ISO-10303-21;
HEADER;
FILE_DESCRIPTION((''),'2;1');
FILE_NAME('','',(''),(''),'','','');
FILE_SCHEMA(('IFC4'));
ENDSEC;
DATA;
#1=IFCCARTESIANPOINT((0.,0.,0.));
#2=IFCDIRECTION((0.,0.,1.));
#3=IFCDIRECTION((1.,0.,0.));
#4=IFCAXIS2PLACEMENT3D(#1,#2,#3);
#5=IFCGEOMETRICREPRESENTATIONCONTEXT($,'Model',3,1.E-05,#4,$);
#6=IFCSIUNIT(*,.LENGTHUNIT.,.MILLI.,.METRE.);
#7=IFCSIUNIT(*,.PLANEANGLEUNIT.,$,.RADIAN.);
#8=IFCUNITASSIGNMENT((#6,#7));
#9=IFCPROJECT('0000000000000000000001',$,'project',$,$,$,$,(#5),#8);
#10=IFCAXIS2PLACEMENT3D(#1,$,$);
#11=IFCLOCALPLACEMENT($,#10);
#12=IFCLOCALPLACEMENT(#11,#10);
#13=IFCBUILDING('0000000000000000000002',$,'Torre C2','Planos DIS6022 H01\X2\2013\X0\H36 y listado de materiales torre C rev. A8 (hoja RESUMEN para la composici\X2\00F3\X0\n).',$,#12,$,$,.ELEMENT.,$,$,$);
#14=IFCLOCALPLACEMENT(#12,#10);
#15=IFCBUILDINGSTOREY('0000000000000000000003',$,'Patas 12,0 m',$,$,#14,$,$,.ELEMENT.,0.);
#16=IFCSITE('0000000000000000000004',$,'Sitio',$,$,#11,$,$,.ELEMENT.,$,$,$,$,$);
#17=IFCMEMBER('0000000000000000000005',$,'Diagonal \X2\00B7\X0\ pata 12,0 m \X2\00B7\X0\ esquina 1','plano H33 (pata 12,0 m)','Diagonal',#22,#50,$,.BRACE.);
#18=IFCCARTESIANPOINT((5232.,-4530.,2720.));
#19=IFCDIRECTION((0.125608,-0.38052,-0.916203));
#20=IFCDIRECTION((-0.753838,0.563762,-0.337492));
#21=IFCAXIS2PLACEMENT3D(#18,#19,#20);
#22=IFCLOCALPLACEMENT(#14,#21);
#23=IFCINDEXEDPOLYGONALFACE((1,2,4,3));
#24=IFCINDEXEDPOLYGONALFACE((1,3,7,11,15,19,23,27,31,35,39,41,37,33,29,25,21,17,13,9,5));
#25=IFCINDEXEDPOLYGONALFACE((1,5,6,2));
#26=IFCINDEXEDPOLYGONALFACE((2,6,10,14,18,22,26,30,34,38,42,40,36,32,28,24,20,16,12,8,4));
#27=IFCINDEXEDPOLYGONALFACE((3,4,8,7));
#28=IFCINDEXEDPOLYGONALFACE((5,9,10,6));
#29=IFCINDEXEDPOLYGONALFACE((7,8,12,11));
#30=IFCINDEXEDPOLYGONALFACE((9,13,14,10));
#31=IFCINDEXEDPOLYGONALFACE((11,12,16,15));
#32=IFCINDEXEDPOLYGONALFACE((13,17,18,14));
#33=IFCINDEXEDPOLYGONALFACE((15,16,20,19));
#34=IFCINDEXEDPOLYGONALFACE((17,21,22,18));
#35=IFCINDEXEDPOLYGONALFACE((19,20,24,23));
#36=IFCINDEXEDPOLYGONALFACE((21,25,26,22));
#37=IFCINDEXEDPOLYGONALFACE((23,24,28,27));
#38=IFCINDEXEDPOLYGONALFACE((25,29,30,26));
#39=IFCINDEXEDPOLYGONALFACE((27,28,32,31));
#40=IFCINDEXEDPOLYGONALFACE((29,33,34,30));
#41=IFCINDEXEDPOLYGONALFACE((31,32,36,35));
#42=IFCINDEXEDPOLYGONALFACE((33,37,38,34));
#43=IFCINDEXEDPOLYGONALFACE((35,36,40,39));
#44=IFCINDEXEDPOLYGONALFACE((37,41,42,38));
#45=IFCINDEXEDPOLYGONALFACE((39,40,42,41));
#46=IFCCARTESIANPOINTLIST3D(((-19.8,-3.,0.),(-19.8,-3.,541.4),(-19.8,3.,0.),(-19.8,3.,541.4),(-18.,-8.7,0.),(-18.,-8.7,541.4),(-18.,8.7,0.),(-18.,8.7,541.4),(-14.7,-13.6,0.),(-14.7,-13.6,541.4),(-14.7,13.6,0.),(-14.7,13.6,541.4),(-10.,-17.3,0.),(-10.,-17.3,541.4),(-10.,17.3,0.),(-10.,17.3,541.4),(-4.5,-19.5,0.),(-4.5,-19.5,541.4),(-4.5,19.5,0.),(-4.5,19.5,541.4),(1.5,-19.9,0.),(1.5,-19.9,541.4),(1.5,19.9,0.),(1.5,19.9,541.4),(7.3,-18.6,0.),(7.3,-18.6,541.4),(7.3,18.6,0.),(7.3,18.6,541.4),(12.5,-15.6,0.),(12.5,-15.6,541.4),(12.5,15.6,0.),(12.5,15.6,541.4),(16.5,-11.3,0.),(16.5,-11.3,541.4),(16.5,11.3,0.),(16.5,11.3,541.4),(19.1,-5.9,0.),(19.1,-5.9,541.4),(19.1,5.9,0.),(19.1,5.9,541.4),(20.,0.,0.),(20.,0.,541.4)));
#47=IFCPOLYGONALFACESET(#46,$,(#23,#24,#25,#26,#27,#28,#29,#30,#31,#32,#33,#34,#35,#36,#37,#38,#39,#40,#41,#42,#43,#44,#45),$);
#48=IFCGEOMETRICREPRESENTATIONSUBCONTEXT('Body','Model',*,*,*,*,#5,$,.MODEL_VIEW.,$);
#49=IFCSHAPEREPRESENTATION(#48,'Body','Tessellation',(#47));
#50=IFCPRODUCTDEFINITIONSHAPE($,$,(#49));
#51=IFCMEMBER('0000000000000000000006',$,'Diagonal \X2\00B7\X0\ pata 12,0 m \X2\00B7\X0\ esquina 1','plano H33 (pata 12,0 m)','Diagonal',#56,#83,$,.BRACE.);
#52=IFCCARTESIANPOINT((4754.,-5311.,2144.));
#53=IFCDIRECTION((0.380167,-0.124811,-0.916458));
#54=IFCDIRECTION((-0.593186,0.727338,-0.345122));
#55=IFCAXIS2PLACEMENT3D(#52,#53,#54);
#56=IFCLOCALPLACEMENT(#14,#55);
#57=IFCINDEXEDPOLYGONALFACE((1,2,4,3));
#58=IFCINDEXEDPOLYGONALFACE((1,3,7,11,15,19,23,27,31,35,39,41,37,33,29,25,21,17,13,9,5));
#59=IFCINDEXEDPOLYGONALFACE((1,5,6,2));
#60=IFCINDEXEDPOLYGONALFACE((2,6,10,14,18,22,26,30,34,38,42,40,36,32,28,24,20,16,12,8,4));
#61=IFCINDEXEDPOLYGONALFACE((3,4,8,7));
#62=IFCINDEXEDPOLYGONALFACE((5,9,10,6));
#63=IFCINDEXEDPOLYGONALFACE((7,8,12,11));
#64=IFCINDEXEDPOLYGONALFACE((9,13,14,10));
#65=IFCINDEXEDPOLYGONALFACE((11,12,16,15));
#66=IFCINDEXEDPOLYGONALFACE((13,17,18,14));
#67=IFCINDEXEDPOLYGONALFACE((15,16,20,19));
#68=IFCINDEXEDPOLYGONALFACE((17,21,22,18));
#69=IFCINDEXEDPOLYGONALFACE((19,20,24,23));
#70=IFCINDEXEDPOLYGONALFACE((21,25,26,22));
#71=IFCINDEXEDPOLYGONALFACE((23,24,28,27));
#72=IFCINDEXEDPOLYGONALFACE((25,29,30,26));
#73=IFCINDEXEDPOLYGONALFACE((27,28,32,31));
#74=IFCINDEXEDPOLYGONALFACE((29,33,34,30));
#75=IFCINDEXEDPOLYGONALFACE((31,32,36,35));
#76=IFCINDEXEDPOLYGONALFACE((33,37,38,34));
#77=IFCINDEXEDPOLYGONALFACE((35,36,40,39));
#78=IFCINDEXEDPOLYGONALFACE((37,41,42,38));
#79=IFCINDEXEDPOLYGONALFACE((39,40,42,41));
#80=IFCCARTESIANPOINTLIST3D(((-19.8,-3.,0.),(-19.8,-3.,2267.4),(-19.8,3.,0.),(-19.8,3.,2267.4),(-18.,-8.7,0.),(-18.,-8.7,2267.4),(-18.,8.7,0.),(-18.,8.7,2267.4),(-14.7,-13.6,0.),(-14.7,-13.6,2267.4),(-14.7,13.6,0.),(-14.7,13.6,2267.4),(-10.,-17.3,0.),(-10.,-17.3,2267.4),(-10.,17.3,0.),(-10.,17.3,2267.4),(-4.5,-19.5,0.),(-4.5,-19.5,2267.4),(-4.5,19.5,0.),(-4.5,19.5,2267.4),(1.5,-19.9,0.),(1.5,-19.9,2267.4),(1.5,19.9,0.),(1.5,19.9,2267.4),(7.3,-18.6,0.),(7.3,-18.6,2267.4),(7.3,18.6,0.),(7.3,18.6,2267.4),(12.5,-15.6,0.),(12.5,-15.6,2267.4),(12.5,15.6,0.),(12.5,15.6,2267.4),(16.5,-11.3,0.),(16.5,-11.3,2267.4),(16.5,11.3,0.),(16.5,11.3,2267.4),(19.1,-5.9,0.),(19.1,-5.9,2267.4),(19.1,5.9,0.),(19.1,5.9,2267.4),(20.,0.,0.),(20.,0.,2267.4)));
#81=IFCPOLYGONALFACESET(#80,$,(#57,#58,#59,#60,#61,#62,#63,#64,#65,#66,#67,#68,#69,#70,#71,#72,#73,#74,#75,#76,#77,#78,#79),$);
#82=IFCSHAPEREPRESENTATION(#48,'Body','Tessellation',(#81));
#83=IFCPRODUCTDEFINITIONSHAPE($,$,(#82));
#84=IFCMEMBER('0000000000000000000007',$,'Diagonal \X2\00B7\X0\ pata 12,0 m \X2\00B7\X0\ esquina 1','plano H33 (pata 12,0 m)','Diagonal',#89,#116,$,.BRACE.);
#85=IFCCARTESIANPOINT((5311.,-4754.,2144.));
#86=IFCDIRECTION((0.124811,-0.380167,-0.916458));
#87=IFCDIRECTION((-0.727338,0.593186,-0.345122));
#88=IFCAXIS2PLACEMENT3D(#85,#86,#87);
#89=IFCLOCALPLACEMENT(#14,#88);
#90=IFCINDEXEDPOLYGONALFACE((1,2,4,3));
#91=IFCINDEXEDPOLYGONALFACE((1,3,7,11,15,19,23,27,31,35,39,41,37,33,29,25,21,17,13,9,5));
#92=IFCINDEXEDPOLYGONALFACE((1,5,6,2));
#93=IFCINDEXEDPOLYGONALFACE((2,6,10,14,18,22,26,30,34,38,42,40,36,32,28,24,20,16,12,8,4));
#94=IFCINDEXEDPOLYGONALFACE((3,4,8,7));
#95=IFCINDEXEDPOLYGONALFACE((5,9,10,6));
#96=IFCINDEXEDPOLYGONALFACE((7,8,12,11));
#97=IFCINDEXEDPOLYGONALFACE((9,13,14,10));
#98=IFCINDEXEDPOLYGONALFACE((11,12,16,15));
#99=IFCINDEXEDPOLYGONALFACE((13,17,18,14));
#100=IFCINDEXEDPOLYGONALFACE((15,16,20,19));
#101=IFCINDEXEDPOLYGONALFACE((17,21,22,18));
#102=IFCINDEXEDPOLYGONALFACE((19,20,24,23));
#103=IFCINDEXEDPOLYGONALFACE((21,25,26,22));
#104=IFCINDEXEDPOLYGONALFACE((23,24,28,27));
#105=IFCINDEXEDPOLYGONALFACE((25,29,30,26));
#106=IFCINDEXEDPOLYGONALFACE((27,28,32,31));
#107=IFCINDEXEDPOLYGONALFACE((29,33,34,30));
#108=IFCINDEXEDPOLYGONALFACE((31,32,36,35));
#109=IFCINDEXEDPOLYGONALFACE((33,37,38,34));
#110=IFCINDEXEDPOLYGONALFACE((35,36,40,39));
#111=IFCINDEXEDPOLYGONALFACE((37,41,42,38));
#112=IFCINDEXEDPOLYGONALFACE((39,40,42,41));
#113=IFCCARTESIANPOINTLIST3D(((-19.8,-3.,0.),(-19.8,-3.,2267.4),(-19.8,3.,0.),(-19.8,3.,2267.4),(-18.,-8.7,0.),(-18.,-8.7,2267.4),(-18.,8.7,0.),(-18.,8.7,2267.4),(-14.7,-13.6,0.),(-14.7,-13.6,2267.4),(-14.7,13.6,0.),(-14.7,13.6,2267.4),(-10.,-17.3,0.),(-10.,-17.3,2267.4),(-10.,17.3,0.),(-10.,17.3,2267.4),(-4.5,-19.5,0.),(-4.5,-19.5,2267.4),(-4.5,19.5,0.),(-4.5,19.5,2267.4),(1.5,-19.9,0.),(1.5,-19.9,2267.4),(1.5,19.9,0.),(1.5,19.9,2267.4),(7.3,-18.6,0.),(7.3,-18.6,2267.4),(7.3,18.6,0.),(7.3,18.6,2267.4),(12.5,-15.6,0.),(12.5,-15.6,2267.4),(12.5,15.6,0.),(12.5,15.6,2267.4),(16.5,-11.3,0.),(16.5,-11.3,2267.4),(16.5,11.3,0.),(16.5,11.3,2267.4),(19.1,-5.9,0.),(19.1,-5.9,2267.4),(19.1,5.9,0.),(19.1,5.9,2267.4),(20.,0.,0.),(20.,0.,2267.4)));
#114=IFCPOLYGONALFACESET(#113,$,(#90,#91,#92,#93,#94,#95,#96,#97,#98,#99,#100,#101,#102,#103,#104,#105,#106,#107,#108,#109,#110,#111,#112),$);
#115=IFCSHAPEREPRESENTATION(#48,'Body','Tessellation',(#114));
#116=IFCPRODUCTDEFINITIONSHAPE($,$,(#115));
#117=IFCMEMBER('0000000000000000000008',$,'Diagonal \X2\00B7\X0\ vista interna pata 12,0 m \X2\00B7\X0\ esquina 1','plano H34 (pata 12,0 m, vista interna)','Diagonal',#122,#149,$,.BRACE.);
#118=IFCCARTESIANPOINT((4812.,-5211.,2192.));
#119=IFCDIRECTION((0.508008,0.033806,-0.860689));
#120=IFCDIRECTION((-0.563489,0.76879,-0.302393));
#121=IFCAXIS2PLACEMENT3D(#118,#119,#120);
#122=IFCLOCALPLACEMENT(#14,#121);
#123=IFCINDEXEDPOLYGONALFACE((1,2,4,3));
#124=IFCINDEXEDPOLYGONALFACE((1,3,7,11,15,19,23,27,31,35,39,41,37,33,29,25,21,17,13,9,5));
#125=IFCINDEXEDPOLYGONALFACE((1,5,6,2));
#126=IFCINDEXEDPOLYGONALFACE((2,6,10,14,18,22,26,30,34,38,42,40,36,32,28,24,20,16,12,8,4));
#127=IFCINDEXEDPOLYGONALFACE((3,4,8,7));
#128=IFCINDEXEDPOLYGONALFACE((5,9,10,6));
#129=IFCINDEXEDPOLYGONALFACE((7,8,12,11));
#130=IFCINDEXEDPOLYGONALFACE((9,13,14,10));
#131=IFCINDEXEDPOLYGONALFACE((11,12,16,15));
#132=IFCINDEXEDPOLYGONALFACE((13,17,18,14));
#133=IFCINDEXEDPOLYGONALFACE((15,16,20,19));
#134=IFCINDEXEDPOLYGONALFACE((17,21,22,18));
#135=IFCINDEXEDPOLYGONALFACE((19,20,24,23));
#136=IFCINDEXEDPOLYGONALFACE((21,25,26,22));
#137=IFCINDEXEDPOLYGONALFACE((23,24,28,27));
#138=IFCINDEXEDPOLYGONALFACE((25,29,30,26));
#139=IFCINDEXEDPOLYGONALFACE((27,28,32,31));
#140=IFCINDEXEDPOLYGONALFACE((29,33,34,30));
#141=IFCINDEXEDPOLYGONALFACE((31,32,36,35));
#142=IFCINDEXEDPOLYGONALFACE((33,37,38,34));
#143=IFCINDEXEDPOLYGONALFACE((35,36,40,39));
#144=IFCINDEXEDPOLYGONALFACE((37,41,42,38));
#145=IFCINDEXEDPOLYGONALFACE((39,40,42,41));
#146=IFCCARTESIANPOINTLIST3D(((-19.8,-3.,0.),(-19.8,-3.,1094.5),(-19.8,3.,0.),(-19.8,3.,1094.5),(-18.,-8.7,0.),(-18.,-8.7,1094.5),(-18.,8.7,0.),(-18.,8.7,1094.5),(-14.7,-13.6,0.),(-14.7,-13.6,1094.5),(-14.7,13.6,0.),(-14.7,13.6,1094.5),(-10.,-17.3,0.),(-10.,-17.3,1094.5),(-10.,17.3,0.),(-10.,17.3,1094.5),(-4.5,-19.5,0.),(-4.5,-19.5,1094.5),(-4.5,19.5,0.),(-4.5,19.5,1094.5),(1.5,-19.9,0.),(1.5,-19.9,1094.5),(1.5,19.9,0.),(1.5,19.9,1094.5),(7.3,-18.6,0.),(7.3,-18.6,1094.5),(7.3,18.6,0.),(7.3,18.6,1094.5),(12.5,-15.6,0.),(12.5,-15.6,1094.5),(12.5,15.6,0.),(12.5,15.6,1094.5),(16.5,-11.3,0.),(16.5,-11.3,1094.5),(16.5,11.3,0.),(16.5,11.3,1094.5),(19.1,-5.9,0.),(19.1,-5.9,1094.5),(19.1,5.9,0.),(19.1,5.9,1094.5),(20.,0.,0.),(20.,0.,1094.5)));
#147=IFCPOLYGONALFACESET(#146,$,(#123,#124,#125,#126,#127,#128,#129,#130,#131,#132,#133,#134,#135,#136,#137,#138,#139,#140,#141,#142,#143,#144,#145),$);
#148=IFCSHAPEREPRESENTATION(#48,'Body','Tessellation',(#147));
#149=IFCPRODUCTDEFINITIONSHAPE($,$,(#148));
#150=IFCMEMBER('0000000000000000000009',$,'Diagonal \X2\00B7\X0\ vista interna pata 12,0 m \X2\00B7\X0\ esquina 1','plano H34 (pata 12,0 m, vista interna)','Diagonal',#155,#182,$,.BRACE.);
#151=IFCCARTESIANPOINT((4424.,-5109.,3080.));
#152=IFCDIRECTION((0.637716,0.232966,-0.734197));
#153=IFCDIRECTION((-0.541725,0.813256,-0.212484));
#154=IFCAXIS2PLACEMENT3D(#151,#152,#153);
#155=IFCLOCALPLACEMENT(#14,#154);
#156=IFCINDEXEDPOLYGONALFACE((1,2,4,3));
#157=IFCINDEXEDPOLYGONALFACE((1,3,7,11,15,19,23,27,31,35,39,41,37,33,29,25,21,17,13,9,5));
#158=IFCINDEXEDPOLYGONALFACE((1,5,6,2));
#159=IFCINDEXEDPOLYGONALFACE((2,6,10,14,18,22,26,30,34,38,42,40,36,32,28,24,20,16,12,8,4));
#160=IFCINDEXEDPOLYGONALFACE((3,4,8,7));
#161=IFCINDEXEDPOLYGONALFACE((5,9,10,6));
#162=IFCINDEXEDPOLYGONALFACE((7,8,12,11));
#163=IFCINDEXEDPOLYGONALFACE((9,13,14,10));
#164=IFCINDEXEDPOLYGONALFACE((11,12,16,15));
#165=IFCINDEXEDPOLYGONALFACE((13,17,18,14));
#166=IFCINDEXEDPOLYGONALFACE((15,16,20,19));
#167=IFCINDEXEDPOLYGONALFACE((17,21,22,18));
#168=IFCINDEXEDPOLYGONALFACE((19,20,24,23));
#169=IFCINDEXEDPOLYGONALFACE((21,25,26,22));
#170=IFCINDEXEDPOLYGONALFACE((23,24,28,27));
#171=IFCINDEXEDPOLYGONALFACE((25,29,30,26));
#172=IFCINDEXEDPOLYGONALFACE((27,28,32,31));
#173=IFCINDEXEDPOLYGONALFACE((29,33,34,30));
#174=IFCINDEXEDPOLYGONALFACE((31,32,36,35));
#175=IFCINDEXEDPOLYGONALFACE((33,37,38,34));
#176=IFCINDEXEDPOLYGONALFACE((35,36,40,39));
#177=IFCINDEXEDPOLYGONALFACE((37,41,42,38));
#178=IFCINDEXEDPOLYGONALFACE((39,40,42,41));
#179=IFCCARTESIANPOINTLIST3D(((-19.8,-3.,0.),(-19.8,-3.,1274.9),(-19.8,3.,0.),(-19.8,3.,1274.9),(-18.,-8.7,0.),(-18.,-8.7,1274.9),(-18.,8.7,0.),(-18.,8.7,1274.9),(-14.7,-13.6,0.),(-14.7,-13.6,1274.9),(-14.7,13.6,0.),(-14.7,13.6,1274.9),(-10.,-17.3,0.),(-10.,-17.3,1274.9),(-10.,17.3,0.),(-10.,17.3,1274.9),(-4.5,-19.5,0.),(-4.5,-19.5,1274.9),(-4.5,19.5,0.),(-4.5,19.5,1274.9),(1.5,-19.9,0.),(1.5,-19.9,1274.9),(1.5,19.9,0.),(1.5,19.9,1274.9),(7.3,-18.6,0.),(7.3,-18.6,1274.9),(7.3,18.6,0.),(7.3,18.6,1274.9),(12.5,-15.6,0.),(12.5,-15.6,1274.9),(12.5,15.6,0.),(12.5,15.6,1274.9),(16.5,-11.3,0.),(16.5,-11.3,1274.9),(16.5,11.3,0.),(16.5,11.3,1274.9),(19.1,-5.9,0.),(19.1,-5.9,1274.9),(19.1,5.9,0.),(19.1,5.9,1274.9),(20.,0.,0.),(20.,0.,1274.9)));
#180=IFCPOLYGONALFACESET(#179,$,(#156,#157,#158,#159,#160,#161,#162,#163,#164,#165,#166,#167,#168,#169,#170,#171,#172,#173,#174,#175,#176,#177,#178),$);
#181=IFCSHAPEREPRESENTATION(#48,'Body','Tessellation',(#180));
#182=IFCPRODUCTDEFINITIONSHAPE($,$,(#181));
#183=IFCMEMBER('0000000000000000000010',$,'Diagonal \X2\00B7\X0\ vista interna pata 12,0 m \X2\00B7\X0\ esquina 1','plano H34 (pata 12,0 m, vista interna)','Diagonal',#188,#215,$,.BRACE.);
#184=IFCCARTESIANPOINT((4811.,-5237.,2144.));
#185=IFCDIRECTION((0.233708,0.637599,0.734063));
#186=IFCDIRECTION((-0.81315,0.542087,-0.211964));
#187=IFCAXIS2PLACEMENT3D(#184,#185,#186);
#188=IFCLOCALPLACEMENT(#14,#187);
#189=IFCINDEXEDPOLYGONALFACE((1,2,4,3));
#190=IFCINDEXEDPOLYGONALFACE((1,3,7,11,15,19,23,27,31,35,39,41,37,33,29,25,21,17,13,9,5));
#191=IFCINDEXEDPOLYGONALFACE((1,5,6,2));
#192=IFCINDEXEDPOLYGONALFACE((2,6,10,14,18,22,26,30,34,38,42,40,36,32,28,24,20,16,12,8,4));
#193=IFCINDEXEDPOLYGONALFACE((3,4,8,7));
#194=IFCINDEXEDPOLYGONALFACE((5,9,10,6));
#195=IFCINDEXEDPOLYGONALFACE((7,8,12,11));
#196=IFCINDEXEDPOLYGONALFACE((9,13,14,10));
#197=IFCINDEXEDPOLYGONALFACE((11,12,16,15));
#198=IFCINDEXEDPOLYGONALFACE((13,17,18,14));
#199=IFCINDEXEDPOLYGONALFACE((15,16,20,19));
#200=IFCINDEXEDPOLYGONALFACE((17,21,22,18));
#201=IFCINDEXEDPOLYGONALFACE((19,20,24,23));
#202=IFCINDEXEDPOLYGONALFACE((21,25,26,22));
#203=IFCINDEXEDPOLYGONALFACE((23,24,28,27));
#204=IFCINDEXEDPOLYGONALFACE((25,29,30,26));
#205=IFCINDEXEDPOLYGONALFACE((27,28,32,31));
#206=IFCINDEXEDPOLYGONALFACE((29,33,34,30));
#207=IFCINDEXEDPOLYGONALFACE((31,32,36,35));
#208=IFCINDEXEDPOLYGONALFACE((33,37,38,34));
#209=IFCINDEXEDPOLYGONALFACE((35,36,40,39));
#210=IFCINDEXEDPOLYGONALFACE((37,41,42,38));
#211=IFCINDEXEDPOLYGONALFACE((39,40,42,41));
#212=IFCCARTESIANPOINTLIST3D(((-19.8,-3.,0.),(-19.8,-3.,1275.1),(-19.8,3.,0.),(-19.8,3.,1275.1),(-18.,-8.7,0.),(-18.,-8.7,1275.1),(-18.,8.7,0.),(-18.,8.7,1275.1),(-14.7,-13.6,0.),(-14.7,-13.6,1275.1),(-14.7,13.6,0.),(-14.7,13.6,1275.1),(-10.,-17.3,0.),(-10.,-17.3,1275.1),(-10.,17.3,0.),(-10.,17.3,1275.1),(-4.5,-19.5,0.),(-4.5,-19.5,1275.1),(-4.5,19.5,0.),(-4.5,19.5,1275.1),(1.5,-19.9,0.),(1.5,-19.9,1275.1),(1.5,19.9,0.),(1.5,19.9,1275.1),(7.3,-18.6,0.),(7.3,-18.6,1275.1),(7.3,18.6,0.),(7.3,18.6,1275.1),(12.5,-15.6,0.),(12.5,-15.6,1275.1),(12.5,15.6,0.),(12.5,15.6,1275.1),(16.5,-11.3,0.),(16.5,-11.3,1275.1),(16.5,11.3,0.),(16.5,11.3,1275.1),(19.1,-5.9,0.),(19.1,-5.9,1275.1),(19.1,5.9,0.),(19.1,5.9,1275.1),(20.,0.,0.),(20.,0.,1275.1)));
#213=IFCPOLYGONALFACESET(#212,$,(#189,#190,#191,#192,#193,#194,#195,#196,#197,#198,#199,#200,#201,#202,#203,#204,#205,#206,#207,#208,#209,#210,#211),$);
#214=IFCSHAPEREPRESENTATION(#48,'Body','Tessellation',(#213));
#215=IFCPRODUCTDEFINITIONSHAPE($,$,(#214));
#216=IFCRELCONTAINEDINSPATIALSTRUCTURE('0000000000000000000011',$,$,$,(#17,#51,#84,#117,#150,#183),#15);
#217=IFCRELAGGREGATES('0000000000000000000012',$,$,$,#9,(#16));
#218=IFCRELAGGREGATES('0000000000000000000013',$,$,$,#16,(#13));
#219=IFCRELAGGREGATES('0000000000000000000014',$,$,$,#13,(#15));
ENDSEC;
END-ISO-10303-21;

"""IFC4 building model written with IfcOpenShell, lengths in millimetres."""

from ifc_helpers import new_model, si_unit, frame, origin, origin_with_axes, place, context, subcontext, project, spatial, circle, extrude, element, save


model = new_model("IFC4")

# Units and contexts
model_context = context("Model", 3, precision=1e-05, world=origin_with_axes())
body_context = subcontext(model_context, "Body", "Model", "MODEL_VIEW")
ifc_project = project(units=[si_unit("LENGTHUNIT", "METRE", prefix="MILLI"), si_unit("PLANEANGLEUNIT", "RADIAN")], contexts=[model_context])

# Site, building, storey
site_placement = place(None, origin())
site = spatial("IfcSite", under=ifc_project, at=site_placement, Name="Sitio", CompositionType="ELEMENT")
building_placement = place(site_placement, origin())
building = spatial("IfcBuilding", under=site, at=building_placement, Name="Torre C2", Description="Planos DIS6022 H01–H36 y listado de materiales torre C rev. A8 (hoja RESUMEN para la composición).", CompositionType="ELEMENT")
storey_placement = place(building_placement, origin())
storey = spatial("IfcBuildingStorey", under=building, at=storey_placement, Name="Patas 12,0 m", CompositionType="ELEMENT", Elevation=0.0)

# Members
for number, where, z_axis, x_axis, name in (
    (1, (5232.0, -4530.0, 2720.0), (0.125608, -0.38052, -0.916203), (-0.753838, 0.563762, -0.337492), "Diagonal · pata 12,0 m · esquina 1"),
):
    element("IfcMember", number, at=place(storey_placement, frame(where, z_axis=z_axis, x_axis=x_axis)), inside=storey, Name=name, Description="plano H33 (pata 12,0 m)", ObjectType="Diagonal", PredefinedType="BRACE", context=body_context, shape_type="SweptSolid", body=[
        extrude(circle(Radius=20.0), None, (0.0, 0.0, 1.0), 541.4),
    ])
for number, where, z_axis, x_axis, name in (
    (2, (4754.0, -5311.0, 2144.0), (0.380167, -0.124811, -0.916458), (-0.593186, 0.727338, -0.345122), "Diagonal · pata 12,0 m · esquina 1"),
    (3, (5311.0, -4754.0, 2144.0), (0.124811, -0.380167, -0.916458), (-0.727338, 0.593186, -0.345122), "Diagonal · pata 12,0 m · esquina 1"),
):
    element("IfcMember", number, at=place(storey_placement, frame(where, z_axis=z_axis, x_axis=x_axis)), inside=storey, Name=name, Description="plano H33 (pata 12,0 m)", ObjectType="Diagonal", PredefinedType="BRACE", context=body_context, shape_type="SweptSolid", body=[
        extrude(circle(Radius=20.0), None, (0.0, 0.0, 1.0), 2267.4),
    ])
member_1_placement = place(storey_placement, frame((4812.0, -5211.0, 2192.0), z_axis=(0.508008, 0.033806, -0.860689), x_axis=(-0.563489, 0.76879, -0.302393)))
element("IfcMember", 4, at=member_1_placement, inside=storey, Name="Diagonal · vista interna pata 12,0 m · esquina 1", Description="plano H34 (pata 12,0 m, vista interna)", ObjectType="Diagonal", PredefinedType="BRACE", context=body_context, shape_type="SweptSolid", body=[
    extrude(circle(Radius=20.0), None, (0.0, 0.0, 1.0), 1094.5),
])
member_2_placement = place(storey_placement, frame((4424.0, -5109.0, 3080.0), z_axis=(0.637716, 0.232966, -0.734197), x_axis=(-0.541725, 0.813256, -0.212484)))
element("IfcMember", 5, at=member_2_placement, inside=storey, Name="Diagonal · vista interna pata 12,0 m · esquina 1", Description="plano H34 (pata 12,0 m, vista interna)", ObjectType="Diagonal", PredefinedType="BRACE", context=body_context, shape_type="SweptSolid", body=[
    extrude(circle(Radius=20.0), None, (0.0, 0.0, 1.0), 1274.9),
])
member_3_placement = place(storey_placement, frame((4811.0, -5237.0, 2144.0), z_axis=(0.233708, 0.637599, 0.734063), x_axis=(-0.81315, 0.542087, -0.211964)))
element("IfcMember", 6, at=member_3_placement, inside=storey, Name="Diagonal · vista interna pata 12,0 m · esquina 1", Description="plano H34 (pata 12,0 m, vista interna)", ObjectType="Diagonal", PredefinedType="BRACE", context=body_context, shape_type="SweptSolid", body=[
    extrude(circle(Radius=20.0), None, (0.0, 0.0, 1.0), 1275.1),
])

save(model, "model.ifc")
